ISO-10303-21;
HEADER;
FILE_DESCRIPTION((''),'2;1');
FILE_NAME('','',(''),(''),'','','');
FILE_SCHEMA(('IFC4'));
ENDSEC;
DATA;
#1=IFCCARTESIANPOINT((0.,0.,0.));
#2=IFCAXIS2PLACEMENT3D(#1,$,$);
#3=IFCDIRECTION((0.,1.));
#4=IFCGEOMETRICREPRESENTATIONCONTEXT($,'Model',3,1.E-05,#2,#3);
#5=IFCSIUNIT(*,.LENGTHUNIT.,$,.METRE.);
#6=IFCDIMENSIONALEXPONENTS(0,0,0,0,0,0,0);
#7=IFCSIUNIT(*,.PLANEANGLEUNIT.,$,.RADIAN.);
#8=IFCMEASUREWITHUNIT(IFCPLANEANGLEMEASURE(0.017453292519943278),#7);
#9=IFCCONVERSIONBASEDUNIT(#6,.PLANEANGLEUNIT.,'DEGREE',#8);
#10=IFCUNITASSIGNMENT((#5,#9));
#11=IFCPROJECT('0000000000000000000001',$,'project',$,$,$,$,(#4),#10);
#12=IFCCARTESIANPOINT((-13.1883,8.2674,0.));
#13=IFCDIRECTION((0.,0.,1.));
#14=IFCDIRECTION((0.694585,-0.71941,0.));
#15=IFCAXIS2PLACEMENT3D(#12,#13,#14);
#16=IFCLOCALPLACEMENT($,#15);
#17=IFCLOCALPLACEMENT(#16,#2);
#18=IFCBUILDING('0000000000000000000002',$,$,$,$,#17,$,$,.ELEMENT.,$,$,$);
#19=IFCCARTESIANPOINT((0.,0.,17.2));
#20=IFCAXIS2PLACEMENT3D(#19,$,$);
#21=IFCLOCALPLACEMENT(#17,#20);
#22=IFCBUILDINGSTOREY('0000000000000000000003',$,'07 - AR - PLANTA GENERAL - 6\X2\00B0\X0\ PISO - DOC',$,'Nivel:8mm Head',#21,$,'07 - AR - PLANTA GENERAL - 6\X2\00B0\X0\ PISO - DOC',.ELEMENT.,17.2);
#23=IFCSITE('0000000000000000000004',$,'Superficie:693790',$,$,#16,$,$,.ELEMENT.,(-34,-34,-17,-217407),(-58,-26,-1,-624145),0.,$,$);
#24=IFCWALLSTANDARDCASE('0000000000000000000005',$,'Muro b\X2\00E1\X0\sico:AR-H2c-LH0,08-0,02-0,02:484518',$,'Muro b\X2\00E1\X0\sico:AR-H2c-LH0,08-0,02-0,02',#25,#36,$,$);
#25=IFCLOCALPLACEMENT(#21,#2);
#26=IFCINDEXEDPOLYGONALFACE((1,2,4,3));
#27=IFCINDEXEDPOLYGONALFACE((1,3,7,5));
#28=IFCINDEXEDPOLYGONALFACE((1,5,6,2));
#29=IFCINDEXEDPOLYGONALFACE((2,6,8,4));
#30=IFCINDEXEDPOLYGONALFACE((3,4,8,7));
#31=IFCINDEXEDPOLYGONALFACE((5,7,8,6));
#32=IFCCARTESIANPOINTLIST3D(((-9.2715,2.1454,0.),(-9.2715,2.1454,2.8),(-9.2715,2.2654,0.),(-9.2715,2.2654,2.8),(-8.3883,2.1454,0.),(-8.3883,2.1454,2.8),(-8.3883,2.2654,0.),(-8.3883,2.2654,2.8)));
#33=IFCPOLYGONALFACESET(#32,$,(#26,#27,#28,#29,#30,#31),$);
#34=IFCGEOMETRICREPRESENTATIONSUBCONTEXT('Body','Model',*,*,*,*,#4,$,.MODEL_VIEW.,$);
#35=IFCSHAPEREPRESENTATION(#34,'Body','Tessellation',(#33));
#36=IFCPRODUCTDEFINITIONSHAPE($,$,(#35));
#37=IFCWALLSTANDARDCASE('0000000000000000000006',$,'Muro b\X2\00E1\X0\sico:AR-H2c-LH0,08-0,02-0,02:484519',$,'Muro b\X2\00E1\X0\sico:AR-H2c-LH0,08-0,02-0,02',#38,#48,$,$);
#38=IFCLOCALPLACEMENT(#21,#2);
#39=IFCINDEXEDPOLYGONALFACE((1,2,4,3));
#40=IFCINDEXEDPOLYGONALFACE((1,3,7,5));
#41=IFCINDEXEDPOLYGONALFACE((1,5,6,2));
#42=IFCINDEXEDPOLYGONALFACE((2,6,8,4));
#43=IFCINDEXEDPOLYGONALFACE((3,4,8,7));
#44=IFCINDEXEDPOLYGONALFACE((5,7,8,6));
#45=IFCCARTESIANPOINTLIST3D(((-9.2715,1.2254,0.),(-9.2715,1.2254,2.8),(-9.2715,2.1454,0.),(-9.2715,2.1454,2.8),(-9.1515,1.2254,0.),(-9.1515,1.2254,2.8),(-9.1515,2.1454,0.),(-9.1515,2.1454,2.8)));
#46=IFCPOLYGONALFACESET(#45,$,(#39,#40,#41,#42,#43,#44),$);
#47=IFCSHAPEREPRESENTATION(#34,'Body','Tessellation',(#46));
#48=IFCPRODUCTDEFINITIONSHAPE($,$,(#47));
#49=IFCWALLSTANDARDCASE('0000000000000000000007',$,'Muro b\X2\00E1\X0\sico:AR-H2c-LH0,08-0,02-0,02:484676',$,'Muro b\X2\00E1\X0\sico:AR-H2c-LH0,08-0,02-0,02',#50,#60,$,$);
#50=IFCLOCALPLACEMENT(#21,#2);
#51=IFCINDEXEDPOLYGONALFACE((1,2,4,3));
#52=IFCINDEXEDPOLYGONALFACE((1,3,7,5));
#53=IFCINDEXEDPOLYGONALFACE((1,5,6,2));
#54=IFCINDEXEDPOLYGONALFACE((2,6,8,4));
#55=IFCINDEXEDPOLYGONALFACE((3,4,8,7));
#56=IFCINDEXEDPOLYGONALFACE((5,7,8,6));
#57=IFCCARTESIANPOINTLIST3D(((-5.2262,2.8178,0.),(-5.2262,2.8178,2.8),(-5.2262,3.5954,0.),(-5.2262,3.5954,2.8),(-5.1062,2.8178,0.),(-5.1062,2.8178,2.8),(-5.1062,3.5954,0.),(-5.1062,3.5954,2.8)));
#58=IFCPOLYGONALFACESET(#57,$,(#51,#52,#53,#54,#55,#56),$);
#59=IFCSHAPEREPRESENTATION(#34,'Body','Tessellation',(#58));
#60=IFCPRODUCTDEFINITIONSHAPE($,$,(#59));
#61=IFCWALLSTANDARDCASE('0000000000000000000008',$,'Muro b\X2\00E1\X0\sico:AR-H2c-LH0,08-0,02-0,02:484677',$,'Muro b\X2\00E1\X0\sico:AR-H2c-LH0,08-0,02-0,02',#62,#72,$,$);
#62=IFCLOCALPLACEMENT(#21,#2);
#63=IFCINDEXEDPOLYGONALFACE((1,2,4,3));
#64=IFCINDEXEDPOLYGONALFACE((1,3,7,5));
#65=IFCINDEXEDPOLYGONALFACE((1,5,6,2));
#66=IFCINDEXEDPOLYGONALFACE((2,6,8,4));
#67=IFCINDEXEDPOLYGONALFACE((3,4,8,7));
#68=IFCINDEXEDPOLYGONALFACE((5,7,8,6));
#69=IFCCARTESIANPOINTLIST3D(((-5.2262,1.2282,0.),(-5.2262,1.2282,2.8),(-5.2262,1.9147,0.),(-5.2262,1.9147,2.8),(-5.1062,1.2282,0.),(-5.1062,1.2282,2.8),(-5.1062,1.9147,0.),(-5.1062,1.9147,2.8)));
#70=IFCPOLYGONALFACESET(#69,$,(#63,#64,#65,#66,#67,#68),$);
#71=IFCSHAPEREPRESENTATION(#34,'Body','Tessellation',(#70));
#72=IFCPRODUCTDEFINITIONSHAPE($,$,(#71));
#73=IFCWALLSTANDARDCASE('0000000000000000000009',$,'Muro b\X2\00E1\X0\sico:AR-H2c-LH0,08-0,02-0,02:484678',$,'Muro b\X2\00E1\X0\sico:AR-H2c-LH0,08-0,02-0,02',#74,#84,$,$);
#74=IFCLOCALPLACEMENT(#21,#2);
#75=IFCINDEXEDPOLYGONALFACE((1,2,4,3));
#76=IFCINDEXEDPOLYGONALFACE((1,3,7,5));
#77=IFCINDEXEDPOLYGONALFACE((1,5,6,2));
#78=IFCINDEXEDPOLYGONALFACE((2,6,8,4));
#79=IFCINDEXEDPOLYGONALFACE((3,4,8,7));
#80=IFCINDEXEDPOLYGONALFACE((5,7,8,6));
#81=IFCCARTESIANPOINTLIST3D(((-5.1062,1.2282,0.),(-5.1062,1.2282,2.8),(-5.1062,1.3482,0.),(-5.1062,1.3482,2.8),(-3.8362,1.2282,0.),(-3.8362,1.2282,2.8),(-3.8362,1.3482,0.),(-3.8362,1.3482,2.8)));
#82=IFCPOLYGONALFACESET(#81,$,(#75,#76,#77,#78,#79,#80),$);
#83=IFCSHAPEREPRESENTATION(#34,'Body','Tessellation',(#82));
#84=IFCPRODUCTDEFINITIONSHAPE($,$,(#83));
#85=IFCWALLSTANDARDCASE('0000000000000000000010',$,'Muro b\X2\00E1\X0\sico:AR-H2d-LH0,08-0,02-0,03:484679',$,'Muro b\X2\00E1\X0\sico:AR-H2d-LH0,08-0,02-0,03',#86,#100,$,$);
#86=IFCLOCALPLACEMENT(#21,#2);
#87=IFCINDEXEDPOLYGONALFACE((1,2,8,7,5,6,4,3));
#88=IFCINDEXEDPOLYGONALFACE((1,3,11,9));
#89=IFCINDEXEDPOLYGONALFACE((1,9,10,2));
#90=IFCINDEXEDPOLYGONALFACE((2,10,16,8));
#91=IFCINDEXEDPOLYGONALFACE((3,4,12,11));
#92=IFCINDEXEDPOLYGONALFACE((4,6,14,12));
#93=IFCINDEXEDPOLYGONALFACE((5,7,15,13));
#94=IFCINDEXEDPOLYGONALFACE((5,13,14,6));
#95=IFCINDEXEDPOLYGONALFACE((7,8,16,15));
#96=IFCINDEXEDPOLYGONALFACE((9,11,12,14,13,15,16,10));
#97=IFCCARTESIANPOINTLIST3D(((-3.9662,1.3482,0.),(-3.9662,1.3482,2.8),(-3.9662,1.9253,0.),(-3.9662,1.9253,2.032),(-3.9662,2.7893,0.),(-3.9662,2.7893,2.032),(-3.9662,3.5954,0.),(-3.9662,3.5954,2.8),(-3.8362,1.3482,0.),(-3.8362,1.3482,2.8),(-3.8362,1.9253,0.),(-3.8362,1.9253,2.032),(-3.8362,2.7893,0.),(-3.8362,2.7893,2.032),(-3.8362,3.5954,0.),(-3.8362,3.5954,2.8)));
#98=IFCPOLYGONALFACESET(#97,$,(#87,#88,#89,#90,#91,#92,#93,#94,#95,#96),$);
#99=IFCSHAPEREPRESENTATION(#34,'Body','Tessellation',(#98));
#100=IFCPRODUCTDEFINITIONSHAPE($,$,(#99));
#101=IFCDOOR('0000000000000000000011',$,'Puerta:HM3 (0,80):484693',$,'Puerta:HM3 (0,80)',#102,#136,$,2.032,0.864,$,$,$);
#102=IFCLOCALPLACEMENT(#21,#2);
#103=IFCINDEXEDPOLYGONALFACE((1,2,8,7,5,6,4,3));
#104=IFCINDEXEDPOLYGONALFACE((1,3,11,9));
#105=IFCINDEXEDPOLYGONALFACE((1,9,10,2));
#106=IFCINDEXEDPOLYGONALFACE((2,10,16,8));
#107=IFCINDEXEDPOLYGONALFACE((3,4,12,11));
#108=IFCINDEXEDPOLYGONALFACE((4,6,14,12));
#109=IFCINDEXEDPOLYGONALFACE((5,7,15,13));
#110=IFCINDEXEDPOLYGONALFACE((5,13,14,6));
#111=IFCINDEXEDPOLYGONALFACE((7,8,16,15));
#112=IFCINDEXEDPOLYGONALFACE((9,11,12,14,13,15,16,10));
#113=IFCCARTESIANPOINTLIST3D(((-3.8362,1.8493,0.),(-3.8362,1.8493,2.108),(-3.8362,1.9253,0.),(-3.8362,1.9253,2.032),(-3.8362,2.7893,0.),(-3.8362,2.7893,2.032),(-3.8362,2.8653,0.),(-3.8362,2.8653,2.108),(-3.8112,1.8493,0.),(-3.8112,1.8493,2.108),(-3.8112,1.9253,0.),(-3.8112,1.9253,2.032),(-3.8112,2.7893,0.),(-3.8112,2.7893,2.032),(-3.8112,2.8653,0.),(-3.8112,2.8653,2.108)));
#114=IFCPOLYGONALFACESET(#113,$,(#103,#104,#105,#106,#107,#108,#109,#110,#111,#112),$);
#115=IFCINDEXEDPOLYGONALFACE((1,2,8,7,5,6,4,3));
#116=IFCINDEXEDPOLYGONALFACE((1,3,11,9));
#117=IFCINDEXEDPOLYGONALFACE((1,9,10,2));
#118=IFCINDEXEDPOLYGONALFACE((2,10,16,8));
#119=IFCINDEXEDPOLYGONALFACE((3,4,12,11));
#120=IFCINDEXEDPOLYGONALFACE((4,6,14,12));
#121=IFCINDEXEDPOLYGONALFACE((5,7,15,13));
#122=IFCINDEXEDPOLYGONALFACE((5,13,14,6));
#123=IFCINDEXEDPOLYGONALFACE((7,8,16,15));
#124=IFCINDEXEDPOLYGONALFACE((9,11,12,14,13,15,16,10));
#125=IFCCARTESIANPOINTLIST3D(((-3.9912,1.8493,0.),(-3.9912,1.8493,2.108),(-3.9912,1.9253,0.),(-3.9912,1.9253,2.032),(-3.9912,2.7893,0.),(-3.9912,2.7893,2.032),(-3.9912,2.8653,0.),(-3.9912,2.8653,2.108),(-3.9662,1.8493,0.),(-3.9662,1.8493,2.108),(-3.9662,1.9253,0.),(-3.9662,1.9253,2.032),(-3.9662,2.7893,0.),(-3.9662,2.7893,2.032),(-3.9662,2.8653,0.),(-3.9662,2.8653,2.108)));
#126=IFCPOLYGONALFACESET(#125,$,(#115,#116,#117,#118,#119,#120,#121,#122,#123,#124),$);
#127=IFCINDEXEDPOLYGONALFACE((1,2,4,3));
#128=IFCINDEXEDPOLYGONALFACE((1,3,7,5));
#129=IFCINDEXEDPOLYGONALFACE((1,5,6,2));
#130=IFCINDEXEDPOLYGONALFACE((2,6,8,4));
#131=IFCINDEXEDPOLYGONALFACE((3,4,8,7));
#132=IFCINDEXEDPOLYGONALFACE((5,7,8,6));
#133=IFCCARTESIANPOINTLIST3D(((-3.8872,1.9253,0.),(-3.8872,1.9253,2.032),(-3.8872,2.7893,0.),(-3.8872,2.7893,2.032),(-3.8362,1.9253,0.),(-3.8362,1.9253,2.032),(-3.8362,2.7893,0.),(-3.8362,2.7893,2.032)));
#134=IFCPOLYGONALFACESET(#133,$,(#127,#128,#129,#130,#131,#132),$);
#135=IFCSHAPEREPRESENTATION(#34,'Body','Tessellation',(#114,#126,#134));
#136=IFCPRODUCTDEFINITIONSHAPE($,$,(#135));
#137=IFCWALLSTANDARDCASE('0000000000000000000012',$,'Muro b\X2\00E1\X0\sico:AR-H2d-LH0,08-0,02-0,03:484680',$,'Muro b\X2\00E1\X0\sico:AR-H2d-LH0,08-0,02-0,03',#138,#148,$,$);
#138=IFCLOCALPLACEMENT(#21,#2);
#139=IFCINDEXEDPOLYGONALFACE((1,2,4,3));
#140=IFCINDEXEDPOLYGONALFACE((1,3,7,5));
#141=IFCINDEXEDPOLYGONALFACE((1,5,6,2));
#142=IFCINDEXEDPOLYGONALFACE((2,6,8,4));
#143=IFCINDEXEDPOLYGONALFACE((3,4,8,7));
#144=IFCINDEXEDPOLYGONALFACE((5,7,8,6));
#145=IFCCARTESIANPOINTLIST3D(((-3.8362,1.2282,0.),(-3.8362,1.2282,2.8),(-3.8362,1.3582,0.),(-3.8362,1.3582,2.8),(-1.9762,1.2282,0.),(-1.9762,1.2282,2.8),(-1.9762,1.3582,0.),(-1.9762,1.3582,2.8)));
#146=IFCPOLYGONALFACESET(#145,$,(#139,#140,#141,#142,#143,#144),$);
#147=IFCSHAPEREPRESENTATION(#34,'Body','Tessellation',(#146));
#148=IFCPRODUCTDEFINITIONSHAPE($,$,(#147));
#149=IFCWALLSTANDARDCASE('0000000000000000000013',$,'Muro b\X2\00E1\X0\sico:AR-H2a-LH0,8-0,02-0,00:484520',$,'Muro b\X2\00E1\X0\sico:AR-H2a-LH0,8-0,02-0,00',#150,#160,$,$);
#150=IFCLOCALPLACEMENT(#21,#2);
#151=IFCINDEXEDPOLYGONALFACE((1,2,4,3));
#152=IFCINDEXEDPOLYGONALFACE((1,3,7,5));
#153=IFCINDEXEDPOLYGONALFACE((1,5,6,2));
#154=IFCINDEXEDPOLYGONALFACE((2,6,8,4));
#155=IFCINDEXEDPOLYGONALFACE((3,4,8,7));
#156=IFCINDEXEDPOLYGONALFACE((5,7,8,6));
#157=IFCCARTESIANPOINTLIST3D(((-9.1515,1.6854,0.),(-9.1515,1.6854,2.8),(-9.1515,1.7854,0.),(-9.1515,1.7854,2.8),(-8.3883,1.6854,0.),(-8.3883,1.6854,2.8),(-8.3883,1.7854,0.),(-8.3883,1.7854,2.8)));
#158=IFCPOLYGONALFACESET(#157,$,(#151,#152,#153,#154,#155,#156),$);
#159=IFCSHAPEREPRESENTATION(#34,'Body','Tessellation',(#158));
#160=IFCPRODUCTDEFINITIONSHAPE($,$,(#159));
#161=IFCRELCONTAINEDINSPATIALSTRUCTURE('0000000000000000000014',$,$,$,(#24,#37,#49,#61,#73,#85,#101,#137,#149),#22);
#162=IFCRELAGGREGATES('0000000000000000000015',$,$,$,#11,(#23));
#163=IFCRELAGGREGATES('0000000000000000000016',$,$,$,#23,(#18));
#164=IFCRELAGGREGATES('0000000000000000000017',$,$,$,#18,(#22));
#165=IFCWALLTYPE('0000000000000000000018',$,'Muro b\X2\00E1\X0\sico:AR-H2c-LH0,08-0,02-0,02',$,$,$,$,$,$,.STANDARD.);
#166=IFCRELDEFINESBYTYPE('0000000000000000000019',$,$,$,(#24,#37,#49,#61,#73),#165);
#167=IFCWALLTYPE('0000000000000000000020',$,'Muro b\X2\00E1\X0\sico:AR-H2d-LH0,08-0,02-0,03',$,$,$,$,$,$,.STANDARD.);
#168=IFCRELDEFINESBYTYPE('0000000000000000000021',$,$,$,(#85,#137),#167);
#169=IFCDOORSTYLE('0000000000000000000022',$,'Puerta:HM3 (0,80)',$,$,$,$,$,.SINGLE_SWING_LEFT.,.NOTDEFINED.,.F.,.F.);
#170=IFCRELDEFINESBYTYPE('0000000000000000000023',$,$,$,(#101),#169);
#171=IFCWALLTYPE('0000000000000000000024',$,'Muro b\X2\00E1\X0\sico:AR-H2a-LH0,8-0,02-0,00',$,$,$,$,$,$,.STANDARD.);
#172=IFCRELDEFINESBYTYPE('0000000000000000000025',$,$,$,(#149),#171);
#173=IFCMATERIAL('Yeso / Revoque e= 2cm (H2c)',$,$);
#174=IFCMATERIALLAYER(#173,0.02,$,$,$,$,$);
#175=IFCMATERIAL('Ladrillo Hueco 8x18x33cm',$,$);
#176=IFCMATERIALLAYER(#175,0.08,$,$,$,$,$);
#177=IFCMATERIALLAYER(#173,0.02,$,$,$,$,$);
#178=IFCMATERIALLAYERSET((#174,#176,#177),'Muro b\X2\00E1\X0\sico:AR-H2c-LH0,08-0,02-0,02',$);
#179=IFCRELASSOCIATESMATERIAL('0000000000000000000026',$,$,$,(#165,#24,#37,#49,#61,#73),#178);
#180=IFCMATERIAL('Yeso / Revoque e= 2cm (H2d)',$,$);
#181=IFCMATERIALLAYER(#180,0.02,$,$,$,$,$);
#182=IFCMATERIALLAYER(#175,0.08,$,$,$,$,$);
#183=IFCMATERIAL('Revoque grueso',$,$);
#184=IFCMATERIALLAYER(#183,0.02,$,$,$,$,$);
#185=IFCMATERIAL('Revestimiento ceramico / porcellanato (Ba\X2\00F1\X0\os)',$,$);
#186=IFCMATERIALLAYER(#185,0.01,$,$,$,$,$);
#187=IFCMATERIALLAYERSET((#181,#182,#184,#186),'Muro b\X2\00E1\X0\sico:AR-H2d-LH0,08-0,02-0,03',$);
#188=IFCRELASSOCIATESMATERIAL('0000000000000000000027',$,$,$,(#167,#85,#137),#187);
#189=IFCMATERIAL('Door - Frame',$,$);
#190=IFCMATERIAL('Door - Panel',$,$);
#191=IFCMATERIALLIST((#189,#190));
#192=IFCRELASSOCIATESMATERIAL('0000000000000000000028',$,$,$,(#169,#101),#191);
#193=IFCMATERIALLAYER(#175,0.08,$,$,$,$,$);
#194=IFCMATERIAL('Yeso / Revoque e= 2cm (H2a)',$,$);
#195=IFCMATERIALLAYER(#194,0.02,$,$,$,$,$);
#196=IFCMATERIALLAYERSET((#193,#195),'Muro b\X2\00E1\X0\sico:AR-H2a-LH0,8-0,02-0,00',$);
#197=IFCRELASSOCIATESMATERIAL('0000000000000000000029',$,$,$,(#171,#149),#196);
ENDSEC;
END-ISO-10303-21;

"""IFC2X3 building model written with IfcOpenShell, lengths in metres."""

from ifc_helpers import new_model, entity, si_unit, converted_unit, direction, frame, frame_2d, origin, place, context, subcontext, project, spatial, polyline, rectangle, outline, extrude, source, transform, mapped, material, material_list, layer, layer_set, layer_usage, type_object, type_shapes, element, fill, save


model = new_model("IFC2X3")

# Units and contexts
model_context = context("Model", 3, precision=1e-05, world=origin(), true_north=direction((0.0, 1.0)))
body_context = subcontext(model_context, "Body", "Model", "MODEL_VIEW")
ifc_project = project(units=[si_unit("LENGTHUNIT", "METRE"), converted_unit("PLANEANGLEUNIT", "DEGREE", entity("IfcPlaneAngleMeasure", 0.017453292519943278), si_unit("PLANEANGLEUNIT", "RADIAN"), dimensions=[0, 0, 0, 0, 0, 0, 0])], contexts=[model_context])

# Site, building, storey
site_placement = place(None, frame((-13.1883, 8.2674, 0.0), z_axis=(0.0, 0.0, 1.0), x_axis=(0.694585, -0.71941, 0.0)))
site = spatial("IfcSite", under=ifc_project, at=site_placement, Name="Superficie:693790", CompositionType="ELEMENT", RefLatitude=(-34, -34, -17, -217407), RefLongitude=(-58, -26, -1, -624145), RefElevation=0.0)
building_placement = place(site_placement, origin())
building = spatial("IfcBuilding", under=site, at=building_placement, CompositionType="ELEMENT")
storey_placement = place(building_placement, frame((0.0, 0.0, 17.2)))
storey = spatial("IfcBuildingStorey", under=building, at=storey_placement, Name="07 - AR - PLANTA GENERAL - 6° PISO - DOC", ObjectType="Nivel:8mm Head", LongName="07 - AR - PLANTA GENERAL - 6° PISO - DOC", CompositionType="ELEMENT", Elevation=17.2)

# Walls
ifc_material_1 = material(Name="Yeso / Revoque e= 2cm (H2c)")
ifc_layer_1 = layer(ifc_material_1, 0.02)
ifc_material_2 = material(Name="Ladrillo Hueco 8x18x33cm")
ifc_layer_2 = layer(ifc_material_2, 0.08)
ifc_layer_3 = layer(ifc_material_1, 0.02)
ifc_layer_set_1 = layer_set([ifc_layer_1, ifc_layer_2, ifc_layer_3], Name="Muro básico:AR-H2c-LH0,08-0,02-0,02")
ifc_layer_usage_1 = layer_usage(ifc_layer_set_1, "AXIS2", "NEGATIVE", 0.06)
wall_type_1 = type_object("IfcWallType", Name="Muro básico:AR-H2c-LH0,08-0,02-0,02", PredefinedType="STANDARD", material=ifc_layer_set_1)
wall_1_placement = place(storey_placement, frame((-9.2715, 2.2054, 0.0)))
element("IfcWallStandardCase", 1, at=wall_1_placement, inside=storey, type_object=wall_type_1, material=ifc_layer_usage_1, Name="Muro básico:AR-H2c-LH0,08-0,02-0,02:484518", ObjectType="Muro básico:AR-H2c-LH0,08-0,02-0,02", context=body_context, shape_type="SweptSolid", body=[
    extrude(rectangle(XDim=0.8832, YDim=0.12, at=frame_2d((0.4416, 0.0), x_axis=(-1.0, 0.0))), origin(), (0.0, 0.0, 1.0), 2.8),
])
ifc_layer_usage_2 = layer_usage(ifc_layer_set_1, "AXIS2", "POSITIVE", -0.06)
wall_2_placement = place(storey_placement, frame((-9.2115, 2.1454, 0.0), z_axis=(0.0, 0.0, 1.0), x_axis=(0.0, -1.0, 0.0)))
element("IfcWallStandardCase", 2, at=wall_2_placement, inside=storey, type_object=wall_type_1, material=ifc_layer_usage_2, Name="Muro básico:AR-H2c-LH0,08-0,02-0,02:484519", ObjectType="Muro básico:AR-H2c-LH0,08-0,02-0,02", context=body_context, shape_type="SweptSolid", body=[
    extrude(rectangle(XDim=0.92, YDim=0.12, at=frame_2d((0.46, 0.0), x_axis=(-1.0, 0.0))), origin(), (0.0, 0.0, 1.0), 2.8),
])
ifc_layer_usage_3 = layer_usage(ifc_layer_set_1, "AXIS2", "POSITIVE", -0.06)
wall_3_placement = place(storey_placement, frame((-5.1662, 3.5954, 0.0), z_axis=(0.0, 0.0, 1.0), x_axis=(0.0, -1.0, 0.0)))
element("IfcWallStandardCase", 3, at=wall_3_placement, inside=storey, type_object=wall_type_1, material=ifc_layer_usage_3, Name="Muro básico:AR-H2c-LH0,08-0,02-0,02:484676", ObjectType="Muro básico:AR-H2c-LH0,08-0,02-0,02", context=body_context, shape_type="SweptSolid", body=[
    extrude(rectangle(XDim=0.7777, YDim=0.12, at=frame_2d((0.3888, 0.0), x_axis=(-1.0, 0.0))), origin(), (0.0, 0.0, 1.0), 2.8),
])
ifc_layer_usage_4 = layer_usage(ifc_layer_set_1, "AXIS2", "POSITIVE", -0.06)
wall_4_placement = place(storey_placement, frame((-5.1662, 1.9147, 0.0), z_axis=(0.0, 0.0, 1.0), x_axis=(0.0, -1.0, 0.0)))
element("IfcWallStandardCase", 4, at=wall_4_placement, inside=storey, type_object=wall_type_1, material=ifc_layer_usage_4, Name="Muro básico:AR-H2c-LH0,08-0,02-0,02:484677", ObjectType="Muro básico:AR-H2c-LH0,08-0,02-0,02", context=body_context, shape_type="SweptSolid", body=[
    extrude(rectangle(XDim=0.6865, YDim=0.12, at=frame_2d((0.3433, 0.0), x_axis=(-1.0, 0.0))), origin(), (0.0, 0.0, 1.0), 2.8),
])
ifc_layer_usage_5 = layer_usage(ifc_layer_set_1, "AXIS2", "POSITIVE", -0.06)
wall_5_placement = place(storey_placement, frame((-5.1062, 1.2882, 0.0)))
element("IfcWallStandardCase", 5, at=wall_5_placement, inside=storey, type_object=wall_type_1, material=ifc_layer_usage_5, Name="Muro básico:AR-H2c-LH0,08-0,02-0,02:484678", ObjectType="Muro básico:AR-H2c-LH0,08-0,02-0,02", context=body_context, shape_type="SweptSolid", body=[
    extrude(rectangle(XDim=1.27, YDim=0.12, at=frame_2d((0.635, 0.0), x_axis=(-1.0, 0.0))), origin(), (0.0, 0.0, 1.0), 2.8),
])

# Wall, opening, door
ifc_material_3 = material(Name="Yeso / Revoque e= 2cm (H2d)")
ifc_layer_4 = layer(ifc_material_3, 0.02)
ifc_layer_5 = layer(ifc_material_2, 0.08)
ifc_material_4 = material(Name="Revoque grueso")
ifc_layer_6 = layer(ifc_material_4, 0.02)
ifc_material_5 = material(Name="Revestimiento ceramico / porcellanato (Baños)")
ifc_layer_7 = layer(ifc_material_5, 0.01)
ifc_layer_set_2 = layer_set([ifc_layer_4, ifc_layer_5, ifc_layer_6, ifc_layer_7], Name="Muro básico:AR-H2d-LH0,08-0,02-0,03")
ifc_layer_usage_6 = layer_usage(ifc_layer_set_2, "AXIS2", "POSITIVE", -0.065)
wall_type_2 = type_object("IfcWallType", Name="Muro básico:AR-H2d-LH0,08-0,02-0,03", PredefinedType="STANDARD", material=ifc_layer_set_2)
wall_6_placement = place(storey_placement, frame((-3.9012, 3.5954, 0.0), z_axis=(0.0, 0.0, 1.0), x_axis=(0.0, -1.0, 0.0)))
wall_6 = element("IfcWallStandardCase", 6, at=wall_6_placement, inside=storey, type_object=wall_type_2, material=ifc_layer_usage_6, Name="Muro básico:AR-H2d-LH0,08-0,02-0,03:484679", ObjectType="Muro básico:AR-H2d-LH0,08-0,02-0,03", context=body_context, shape_type="SweptSolid", body=[
    extrude(rectangle(XDim=2.2473, YDim=0.13, at=frame_2d((1.1236, 0.0), x_axis=(1.0, 0.0))), origin(), (0.0, 0.0, 1.0), 2.8),
])
opening_1_placement = place(wall_6_placement, frame((0.8061, -0.065, 0.0)))
opening_1 = element("IfcOpeningElement", 7, at=opening_1_placement, cuts=wall_6, ObjectType="Opening", context=body_context, shape_type="SweptSolid", body=[
    extrude(rectangle(XDim=0.864, YDim=2.032, at=frame_2d((1.016, 0.432), x_axis=(0.0, -1.0))), frame((0.0, 0.0, 0.0), z_axis=(0.0, 1.0, 0.0), x_axis=(0.0, 0.0, 1.0)), (0.0, 0.0, 1.0), 0.13),
])
ifc_material_6 = material(Name="Door - Frame")
ifc_material_7 = material(Name="Door - Panel")
ifc_material_list_1 = material_list([ifc_material_6, ifc_material_7])
door_style = type_object("IfcDoorStyle", Name="Puerta:HM3 (0,80)", ConstructionType="NOTDEFINED", OperationType="SINGLE_SWING_LEFT", ParameterTakesPrecedence=False, Sizeable=False, material=ifc_material_list_1)
shared_shape_1 = source(origin(), body_context, "Body", "SweptSolid", [
    extrude(outline(polyline([(-0.508, -1.073), (0.508, -1.073), (0.508, 1.035), (0.432, 1.035), (0.432, -0.997), (-0.432, -0.997), (-0.432, 1.035), (-0.508, 1.035), (-0.508, -1.073)])), frame((0.432, 0.155, 1.035), z_axis=(0.0, -1.0, 0.0), x_axis=(-1.0, 0.0, 0.0)), (0.0, 0.0, 1.0), 0.025),
    extrude(outline(polyline([(-1.073, -0.508), (1.035, -0.508), (1.035, -0.432), (-0.997, -0.432), (-0.997, 0.432), (1.035, 0.432), (1.035, 0.508), (-1.073, 0.508), (-1.073, -0.508)])), frame((0.432, 0.0, 1.035), z_axis=(0.0, -1.0, 0.0), x_axis=(0.0, 0.0, -1.0)), (0.0, 0.0, 1.0), 0.025),
    extrude(rectangle(XDim=0.864, YDim=0.051, at=frame_2d((0.0, 0.0), x_axis=(1.0, 0.0))), frame((0.432, 0.1045, 0.0)), (0.0, 0.0, 1.0), 2.032),
])
type_shapes(door_style, [shared_shape_1])
door_placement = place(opening_1_placement, origin())
door = element("IfcDoor", 8, at=door_placement, inside=storey, type_object=door_style, material=ifc_material_list_1, Name="Puerta:HM3 (0,80):484693", ObjectType="Puerta:HM3 (0,80)", OverallHeight=2.032, OverallWidth=0.864, context=body_context, shape_type="MappedRepresentation", body=[
    mapped(shared_shape_1, transform((0.0, 0.0, 0.0), scale=1.0)),
])
fill(opening_1, door)

# Walls
ifc_layer_usage_7 = layer_usage(ifc_layer_set_2, "AXIS2", "POSITIVE", -0.065)
wall_7_placement = place(storey_placement, frame((-3.8362, 1.2932, 0.0)))
element("IfcWallStandardCase", 9, at=wall_7_placement, inside=storey, type_object=wall_type_2, material=ifc_layer_usage_7, Name="Muro básico:AR-H2d-LH0,08-0,02-0,03:484680", ObjectType="Muro básico:AR-H2d-LH0,08-0,02-0,03", context=body_context, shape_type="SweptSolid", body=[
    extrude(rectangle(XDim=1.86, YDim=0.13, at=frame_2d((0.93, 0.0), x_axis=(-1.0, 0.0))), origin(), (0.0, 0.0, 1.0), 2.8),
])
ifc_layer_8 = layer(ifc_material_2, 0.08)
ifc_material_8 = material(Name="Yeso / Revoque e= 2cm (H2a)")
ifc_layer_9 = layer(ifc_material_8, 0.02)
ifc_layer_set_3 = layer_set([ifc_layer_8, ifc_layer_9], Name="Muro básico:AR-H2a-LH0,8-0,02-0,00")
ifc_layer_usage_8 = layer_usage(ifc_layer_set_3, "AXIS2", "NEGATIVE", 0.05)
wall_type_3 = type_object("IfcWallType", Name="Muro básico:AR-H2a-LH0,8-0,02-0,00", PredefinedType="STANDARD", material=ifc_layer_set_3)
wall_8_placement = place(storey_placement, frame((-9.1515, 1.7354, 0.0)))
element("IfcWallStandardCase", 10, at=wall_8_placement, inside=storey, type_object=wall_type_3, material=ifc_layer_usage_8, Name="Muro básico:AR-H2a-LH0,8-0,02-0,00:484520", ObjectType="Muro básico:AR-H2a-LH0,8-0,02-0,00", context=body_context, shape_type="SweptSolid", body=[
    extrude(rectangle(XDim=0.7632, YDim=0.1, at=frame_2d((0.3816, 0.0), x_axis=(-1.0, 0.0))), origin(), (0.0, 0.0, 1.0), 2.8),
])

save(model, "model.ifc")
